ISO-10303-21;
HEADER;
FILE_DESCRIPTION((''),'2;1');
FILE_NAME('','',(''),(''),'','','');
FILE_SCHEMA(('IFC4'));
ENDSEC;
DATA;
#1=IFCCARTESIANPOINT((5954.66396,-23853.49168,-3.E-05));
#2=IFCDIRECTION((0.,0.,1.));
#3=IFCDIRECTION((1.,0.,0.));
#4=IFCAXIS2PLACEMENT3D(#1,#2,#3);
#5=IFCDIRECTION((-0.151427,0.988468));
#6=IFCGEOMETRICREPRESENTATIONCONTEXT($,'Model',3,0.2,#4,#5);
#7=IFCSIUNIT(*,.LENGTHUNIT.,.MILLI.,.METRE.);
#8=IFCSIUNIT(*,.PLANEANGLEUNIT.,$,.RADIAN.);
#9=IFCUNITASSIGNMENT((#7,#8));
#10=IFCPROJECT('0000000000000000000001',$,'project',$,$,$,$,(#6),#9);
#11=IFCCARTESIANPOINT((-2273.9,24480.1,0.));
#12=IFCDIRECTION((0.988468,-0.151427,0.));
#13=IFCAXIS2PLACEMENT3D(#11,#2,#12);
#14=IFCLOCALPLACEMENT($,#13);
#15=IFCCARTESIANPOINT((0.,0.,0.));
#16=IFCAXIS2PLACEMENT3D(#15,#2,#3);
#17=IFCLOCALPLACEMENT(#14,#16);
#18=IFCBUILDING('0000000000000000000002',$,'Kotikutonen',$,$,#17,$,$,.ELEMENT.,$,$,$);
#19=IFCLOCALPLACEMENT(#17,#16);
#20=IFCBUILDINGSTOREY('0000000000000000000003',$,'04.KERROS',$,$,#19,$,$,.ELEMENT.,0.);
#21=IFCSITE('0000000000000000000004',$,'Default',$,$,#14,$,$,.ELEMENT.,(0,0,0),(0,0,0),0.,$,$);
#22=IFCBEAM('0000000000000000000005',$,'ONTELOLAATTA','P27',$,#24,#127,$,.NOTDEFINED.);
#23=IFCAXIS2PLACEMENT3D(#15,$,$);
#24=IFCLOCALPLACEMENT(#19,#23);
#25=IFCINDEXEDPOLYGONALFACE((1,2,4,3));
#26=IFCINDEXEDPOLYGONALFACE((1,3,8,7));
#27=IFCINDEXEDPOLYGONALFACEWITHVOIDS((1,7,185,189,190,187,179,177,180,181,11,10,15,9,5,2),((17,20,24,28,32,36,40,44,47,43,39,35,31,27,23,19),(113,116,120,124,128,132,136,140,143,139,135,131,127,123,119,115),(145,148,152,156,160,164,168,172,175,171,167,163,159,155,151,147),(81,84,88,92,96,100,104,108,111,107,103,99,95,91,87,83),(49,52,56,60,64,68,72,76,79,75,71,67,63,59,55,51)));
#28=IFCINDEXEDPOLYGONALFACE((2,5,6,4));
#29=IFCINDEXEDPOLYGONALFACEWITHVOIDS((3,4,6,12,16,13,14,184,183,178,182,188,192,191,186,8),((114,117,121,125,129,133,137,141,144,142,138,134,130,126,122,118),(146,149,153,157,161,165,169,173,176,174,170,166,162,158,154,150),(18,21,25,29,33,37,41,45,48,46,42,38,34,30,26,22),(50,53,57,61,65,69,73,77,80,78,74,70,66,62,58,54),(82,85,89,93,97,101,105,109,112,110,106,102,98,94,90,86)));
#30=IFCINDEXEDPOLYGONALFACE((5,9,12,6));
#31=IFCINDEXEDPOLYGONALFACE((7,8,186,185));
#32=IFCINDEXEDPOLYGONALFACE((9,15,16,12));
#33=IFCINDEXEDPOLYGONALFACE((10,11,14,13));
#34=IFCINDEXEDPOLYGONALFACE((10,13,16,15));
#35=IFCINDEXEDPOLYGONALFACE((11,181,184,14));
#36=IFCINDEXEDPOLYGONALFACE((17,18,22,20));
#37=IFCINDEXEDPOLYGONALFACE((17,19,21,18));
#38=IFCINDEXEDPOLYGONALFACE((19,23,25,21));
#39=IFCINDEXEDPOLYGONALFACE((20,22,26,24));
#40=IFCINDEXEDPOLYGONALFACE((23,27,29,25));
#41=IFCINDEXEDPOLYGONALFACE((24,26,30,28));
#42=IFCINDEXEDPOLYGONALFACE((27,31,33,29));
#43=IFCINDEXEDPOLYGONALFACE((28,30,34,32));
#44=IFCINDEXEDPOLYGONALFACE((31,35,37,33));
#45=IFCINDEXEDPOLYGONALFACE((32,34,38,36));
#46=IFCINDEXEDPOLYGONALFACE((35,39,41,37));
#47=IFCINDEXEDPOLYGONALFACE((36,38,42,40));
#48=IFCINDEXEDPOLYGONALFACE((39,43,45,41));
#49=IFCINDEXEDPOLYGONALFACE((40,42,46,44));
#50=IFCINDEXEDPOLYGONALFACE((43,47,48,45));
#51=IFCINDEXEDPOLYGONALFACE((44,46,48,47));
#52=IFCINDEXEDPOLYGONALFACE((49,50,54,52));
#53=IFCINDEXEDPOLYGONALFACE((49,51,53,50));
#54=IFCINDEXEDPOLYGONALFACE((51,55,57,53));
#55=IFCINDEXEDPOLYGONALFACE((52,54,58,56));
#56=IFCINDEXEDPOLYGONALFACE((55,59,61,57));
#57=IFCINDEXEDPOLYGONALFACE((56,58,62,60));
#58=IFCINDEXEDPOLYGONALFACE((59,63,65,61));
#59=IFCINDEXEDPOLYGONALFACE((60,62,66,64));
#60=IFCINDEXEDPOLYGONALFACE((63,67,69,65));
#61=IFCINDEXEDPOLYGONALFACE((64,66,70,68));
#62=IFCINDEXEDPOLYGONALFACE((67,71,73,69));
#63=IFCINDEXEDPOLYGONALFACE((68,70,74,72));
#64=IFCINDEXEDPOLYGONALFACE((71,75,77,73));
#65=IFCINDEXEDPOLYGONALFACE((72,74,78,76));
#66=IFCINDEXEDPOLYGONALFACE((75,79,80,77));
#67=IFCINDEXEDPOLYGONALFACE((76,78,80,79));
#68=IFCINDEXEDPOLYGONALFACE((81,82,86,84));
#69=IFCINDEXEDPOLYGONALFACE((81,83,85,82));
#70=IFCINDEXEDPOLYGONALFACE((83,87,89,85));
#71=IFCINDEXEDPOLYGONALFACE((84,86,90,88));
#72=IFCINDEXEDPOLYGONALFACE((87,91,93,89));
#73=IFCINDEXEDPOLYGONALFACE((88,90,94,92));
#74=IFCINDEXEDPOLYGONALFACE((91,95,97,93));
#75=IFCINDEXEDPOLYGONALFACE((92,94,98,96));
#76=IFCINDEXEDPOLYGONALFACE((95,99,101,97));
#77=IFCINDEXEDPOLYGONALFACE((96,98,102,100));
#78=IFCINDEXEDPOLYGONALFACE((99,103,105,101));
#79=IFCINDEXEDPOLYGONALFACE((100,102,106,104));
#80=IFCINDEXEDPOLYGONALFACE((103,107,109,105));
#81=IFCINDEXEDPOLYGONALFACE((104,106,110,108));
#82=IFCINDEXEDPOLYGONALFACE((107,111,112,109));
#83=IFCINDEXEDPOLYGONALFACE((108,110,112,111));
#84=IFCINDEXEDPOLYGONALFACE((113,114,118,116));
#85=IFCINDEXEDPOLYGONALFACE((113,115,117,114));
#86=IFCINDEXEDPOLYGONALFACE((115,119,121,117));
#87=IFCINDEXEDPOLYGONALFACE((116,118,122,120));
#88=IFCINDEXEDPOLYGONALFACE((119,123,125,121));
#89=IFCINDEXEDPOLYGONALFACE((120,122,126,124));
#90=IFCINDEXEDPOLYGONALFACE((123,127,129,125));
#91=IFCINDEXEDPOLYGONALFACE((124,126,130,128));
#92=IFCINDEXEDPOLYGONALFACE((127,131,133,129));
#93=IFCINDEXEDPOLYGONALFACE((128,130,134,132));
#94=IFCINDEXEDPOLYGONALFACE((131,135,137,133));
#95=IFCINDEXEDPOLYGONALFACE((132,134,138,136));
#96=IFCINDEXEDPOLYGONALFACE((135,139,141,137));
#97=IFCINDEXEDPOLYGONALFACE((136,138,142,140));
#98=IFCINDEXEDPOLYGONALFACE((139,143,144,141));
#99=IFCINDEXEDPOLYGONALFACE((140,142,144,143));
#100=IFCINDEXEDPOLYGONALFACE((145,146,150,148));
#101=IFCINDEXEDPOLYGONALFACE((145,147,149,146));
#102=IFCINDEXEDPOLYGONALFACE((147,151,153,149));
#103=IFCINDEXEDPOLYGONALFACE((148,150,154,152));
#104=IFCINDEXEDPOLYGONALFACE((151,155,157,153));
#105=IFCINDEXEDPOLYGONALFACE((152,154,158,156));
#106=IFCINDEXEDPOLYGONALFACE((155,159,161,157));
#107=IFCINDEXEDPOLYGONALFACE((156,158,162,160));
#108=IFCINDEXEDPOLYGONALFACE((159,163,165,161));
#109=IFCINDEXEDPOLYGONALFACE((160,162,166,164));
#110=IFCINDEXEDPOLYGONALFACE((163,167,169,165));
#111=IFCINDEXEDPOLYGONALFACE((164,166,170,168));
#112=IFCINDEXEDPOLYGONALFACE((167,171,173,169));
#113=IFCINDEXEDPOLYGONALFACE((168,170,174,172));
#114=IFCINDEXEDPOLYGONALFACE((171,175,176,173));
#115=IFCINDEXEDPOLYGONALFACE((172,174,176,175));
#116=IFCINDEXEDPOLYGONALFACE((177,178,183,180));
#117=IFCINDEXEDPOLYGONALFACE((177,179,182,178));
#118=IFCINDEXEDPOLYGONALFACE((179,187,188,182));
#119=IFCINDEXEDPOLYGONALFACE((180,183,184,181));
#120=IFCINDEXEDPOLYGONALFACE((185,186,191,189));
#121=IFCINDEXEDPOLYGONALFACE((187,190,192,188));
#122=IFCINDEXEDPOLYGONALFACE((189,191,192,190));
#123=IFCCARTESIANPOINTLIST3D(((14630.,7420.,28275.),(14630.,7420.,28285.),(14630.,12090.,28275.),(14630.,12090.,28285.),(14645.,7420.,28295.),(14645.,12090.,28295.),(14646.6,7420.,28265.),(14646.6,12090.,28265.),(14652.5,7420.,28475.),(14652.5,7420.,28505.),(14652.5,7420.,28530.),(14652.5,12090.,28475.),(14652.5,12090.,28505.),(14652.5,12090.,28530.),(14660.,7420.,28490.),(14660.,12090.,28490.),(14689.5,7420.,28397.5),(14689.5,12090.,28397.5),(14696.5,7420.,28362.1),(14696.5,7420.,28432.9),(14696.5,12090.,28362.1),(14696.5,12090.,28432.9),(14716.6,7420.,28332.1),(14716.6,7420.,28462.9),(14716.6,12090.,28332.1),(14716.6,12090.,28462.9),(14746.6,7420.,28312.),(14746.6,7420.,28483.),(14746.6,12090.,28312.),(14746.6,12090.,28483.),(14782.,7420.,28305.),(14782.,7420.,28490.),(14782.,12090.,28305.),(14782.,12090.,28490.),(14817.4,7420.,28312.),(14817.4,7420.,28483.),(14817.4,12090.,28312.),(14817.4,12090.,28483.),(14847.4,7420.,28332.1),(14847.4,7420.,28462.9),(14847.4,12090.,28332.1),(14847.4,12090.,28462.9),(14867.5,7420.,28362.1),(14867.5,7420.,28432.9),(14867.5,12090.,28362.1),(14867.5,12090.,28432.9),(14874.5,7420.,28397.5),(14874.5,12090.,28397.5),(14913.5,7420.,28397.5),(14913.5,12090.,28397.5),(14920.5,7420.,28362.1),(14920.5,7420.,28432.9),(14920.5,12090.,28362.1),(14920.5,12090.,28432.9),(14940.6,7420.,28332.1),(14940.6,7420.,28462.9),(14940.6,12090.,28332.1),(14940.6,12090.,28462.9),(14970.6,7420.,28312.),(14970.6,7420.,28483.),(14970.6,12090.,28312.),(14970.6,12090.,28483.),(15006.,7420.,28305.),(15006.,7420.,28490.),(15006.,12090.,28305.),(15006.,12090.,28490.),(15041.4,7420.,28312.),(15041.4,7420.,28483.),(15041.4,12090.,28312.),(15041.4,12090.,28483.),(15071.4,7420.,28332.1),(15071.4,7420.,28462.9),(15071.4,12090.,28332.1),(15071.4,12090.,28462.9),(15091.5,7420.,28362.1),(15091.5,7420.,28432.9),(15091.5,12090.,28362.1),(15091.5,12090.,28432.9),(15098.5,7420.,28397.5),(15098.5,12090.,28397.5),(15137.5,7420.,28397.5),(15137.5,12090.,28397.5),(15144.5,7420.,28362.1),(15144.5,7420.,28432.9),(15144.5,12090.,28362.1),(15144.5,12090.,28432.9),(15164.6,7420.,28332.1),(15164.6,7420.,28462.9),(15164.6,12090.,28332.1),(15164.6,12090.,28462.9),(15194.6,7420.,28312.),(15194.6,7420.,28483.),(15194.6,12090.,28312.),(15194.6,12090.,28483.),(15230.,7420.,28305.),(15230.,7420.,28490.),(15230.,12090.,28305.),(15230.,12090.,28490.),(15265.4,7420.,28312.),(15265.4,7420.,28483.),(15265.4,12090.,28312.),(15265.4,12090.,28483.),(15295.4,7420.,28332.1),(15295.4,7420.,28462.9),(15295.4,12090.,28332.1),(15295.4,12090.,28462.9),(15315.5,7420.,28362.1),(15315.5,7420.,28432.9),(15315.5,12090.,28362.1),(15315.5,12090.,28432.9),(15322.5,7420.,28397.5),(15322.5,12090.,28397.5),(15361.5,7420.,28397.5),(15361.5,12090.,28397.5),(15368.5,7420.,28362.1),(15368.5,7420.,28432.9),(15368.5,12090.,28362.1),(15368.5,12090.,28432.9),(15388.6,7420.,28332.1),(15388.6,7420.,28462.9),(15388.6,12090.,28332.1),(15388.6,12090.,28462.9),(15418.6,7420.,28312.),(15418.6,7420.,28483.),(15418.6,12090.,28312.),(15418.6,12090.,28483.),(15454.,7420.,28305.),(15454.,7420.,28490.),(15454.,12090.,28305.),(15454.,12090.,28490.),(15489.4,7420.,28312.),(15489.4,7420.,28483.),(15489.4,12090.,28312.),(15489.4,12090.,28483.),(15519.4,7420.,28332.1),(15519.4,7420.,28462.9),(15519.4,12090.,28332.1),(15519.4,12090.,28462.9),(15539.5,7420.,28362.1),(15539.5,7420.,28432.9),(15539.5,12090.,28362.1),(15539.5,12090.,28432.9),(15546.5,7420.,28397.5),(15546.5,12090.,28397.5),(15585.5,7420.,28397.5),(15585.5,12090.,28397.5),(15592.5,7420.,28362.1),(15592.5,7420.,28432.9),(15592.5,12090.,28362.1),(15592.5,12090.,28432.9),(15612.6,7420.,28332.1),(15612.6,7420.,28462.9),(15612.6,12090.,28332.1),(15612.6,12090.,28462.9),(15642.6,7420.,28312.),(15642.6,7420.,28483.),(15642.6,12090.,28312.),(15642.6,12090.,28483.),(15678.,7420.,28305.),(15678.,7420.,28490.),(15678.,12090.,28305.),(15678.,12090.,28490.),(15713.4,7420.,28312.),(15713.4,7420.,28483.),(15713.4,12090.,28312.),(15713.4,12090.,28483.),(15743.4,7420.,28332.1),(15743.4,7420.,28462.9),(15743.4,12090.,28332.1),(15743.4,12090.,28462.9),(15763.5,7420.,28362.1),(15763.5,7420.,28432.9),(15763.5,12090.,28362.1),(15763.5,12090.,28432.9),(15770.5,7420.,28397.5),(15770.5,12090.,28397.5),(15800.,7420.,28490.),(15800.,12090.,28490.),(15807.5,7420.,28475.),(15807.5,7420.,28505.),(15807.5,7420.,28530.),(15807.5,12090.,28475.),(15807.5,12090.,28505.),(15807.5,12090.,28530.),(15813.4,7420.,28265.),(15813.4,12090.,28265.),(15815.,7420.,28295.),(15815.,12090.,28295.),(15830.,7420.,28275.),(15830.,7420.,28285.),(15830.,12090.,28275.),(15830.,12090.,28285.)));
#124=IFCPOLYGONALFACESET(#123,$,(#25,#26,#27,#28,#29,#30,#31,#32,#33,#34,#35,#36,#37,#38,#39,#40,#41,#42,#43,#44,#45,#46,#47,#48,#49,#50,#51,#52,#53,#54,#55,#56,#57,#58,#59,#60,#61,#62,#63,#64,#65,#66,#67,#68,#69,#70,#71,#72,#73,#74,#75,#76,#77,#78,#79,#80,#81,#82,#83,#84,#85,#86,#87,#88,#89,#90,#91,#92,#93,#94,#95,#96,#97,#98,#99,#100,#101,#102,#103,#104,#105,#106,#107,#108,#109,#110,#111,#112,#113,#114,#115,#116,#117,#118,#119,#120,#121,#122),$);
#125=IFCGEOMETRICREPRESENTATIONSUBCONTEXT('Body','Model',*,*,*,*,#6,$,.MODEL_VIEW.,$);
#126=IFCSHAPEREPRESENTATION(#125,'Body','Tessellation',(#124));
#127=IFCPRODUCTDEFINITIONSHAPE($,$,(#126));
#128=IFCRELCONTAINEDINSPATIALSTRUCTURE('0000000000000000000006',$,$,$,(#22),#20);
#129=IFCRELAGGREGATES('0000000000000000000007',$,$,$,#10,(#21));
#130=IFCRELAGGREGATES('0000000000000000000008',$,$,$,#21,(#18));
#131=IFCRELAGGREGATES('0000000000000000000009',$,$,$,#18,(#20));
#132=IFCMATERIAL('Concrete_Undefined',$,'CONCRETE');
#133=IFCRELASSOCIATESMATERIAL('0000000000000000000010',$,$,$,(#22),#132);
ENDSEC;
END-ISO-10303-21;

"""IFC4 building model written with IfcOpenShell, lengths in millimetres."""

from ifc_helpers import new_model, si_unit, direction, frame, origin_with_axes, place, context, subcontext, project, spatial, line, indexed_curve, outline, extrude, material, element, save


model = new_model("IFC4")

# Units and contexts
model_context = context("Model", 3, precision=0.2, world=frame((5954.66396, -23853.49168, -3e-05), z_axis=(0.0, 0.0, 1.0), x_axis=(1.0, 0.0, 0.0)), true_north=direction((-0.151427, 0.988468)))
body_context = subcontext(model_context, "Body", "Model", "MODEL_VIEW")
ifc_project = project(units=[si_unit("LENGTHUNIT", "METRE", prefix="MILLI"), si_unit("PLANEANGLEUNIT", "RADIAN")], contexts=[model_context])

# Site, building, storey
site_placement = place(None, frame((-2273.9, 24480.1, 0.0), z_axis=(0.0, 0.0, 1.0), x_axis=(0.988468, -0.151427, 0.0)))
site = spatial("IfcSite", under=ifc_project, at=site_placement, Name="Default", CompositionType="ELEMENT", RefLatitude=(0, 0, 0), RefLongitude=(0, 0, 0), RefElevation=0.0)
building_placement = place(site_placement, origin_with_axes())
building = spatial("IfcBuilding", under=site, at=building_placement, Name="Kotikutonen", CompositionType="ELEMENT")
storey_placement = place(building_placement, origin_with_axes())
storey = spatial("IfcBuildingStorey", under=building, at=storey_placement, Name="04.KERROS", CompositionType="ELEMENT", Elevation=0.0)

# Beam
ifc_material_1 = material(Name="Concrete_Undefined", Category="CONCRETE")
beam_1_placement = place(storey_placement, frame((15230.0, 12090.0, 28397.5), z_axis=(-1.0, 0.0, 0.0), x_axis=(0.0, -1.0, 0.0)))
element("IfcBeam", 1, at=beam_1_placement, inside=storey, material=ifc_material_1, Name="ONTELOLAATTA", Description="P27", PredefinedType="NOTDEFINED", context=body_context, shape_type="SolidModel", body=[
    extrude(outline(indexed_curve([(-600.0, -122.5), (-583.4, -132.5), (583.4, -132.5), (600.0, -122.5), (600.0, -112.5), (585.0, -102.5), (577.5, 77.5), (570.0, 92.5), (577.5, 107.5), (577.5, 132.5), (-577.5, 132.5), (-577.5, 107.5), (-570.0, 92.5), (-577.5, 77.5), (-585.0, -102.5), (-600.0, -112.5)], segments=[line(1, 2, 3, 4, 5, 6, 7, 8, 9, 10, 11, 12, 13, 14, 15, 16, 1)]), holes=[indexed_curve([(-448.0, -92.5), (-483.4, -85.5), (-513.4, -65.4), (-533.5, -35.4), (-540.5, 0.0), (-533.5, 35.4), (-513.4, 65.4), (-483.4, 85.5), (-448.0, 92.5), (-412.6, 85.5), (-382.6, 65.4), (-362.5, 35.4), (-355.5, 0.0), (-362.5, -35.4), (-382.6, -65.4), (-412.6, -85.5)], segments=[line(1, 2, 3, 4, 5, 6, 7, 8, 9, 10, 11, 12, 13, 14, 15, 16, 1)]), indexed_curve([(-224.0, -92.5), (-259.4, -85.5), (-289.4, -65.4), (-309.5, -35.4), (-316.5, 0.0), (-309.5, 35.4), (-289.4, 65.4), (-259.4, 85.5), (-224.0, 92.5), (-188.6, 85.5), (-158.6, 65.4), (-138.5, 35.4), (-131.5, 0.0), (-138.5, -35.4), (-158.6, -65.4), (-188.6, -85.5)], segments=[line(1, 2, 3, 4, 5, 6, 7, 8, 9, 10, 11, 12, 13, 14, 15, 16, 1)]), indexed_curve([(0.0, -92.5), (-35.4, -85.5), (-65.4, -65.4), (-85.5, -35.4), (-92.5, 0.0), (-85.5, 35.4), (-65.4, 65.4), (-35.4, 85.5), (0.0, 92.5), (35.4, 85.5), (65.4, 65.4), (85.5, 35.4), (92.5, 0.0), (85.5, -35.4), (65.4, -65.4), (35.4, -85.5)], segments=[line(1, 2, 3, 4, 5, 6, 7, 8, 9, 10, 11, 12, 13, 14, 15, 16, 1)]), indexed_curve([(224.0, -92.5), (188.6, -85.5), (158.6, -65.4), (138.5, -35.4), (131.5, 0.0), (138.5, 35.4), (158.6, 65.4), (188.6, 85.5), (224.0, 92.5), (259.4, 85.5), (289.4, 65.4), (309.5, 35.4), (316.5, 0.0), (309.5, -35.4), (289.4, -65.4), (259.4, -85.5)], segments=[line(1, 2, 3, 4, 5, 6, 7, 8, 9, 10, 11, 12, 13, 14, 15, 16, 1)]), indexed_curve([(448.0, -92.5), (412.6, -85.5), (382.6, -65.4), (362.5, -35.4), (355.5, 0.0), (362.5, 35.4), (382.6, 65.4), (412.6, 85.5), (448.0, 92.5), (483.4, 85.5), (513.4, 65.4), (533.5, 35.4), (540.5, 0.0), (533.5, -35.4), (513.4, -65.4), (483.4, -85.5)], segments=[line(1, 2, 3, 4, 5, 6, 7, 8, 9, 10, 11, 12, 13, 14, 15, 16, 1)])]), frame((0.0, 0.0, 0.0), z_axis=(-1.0, 0.0, 0.0), x_axis=(0.0, 0.0, 1.0)), (0.0, 0.0, -1.0), 4670.0),
])

save(model, "model.ifc")
